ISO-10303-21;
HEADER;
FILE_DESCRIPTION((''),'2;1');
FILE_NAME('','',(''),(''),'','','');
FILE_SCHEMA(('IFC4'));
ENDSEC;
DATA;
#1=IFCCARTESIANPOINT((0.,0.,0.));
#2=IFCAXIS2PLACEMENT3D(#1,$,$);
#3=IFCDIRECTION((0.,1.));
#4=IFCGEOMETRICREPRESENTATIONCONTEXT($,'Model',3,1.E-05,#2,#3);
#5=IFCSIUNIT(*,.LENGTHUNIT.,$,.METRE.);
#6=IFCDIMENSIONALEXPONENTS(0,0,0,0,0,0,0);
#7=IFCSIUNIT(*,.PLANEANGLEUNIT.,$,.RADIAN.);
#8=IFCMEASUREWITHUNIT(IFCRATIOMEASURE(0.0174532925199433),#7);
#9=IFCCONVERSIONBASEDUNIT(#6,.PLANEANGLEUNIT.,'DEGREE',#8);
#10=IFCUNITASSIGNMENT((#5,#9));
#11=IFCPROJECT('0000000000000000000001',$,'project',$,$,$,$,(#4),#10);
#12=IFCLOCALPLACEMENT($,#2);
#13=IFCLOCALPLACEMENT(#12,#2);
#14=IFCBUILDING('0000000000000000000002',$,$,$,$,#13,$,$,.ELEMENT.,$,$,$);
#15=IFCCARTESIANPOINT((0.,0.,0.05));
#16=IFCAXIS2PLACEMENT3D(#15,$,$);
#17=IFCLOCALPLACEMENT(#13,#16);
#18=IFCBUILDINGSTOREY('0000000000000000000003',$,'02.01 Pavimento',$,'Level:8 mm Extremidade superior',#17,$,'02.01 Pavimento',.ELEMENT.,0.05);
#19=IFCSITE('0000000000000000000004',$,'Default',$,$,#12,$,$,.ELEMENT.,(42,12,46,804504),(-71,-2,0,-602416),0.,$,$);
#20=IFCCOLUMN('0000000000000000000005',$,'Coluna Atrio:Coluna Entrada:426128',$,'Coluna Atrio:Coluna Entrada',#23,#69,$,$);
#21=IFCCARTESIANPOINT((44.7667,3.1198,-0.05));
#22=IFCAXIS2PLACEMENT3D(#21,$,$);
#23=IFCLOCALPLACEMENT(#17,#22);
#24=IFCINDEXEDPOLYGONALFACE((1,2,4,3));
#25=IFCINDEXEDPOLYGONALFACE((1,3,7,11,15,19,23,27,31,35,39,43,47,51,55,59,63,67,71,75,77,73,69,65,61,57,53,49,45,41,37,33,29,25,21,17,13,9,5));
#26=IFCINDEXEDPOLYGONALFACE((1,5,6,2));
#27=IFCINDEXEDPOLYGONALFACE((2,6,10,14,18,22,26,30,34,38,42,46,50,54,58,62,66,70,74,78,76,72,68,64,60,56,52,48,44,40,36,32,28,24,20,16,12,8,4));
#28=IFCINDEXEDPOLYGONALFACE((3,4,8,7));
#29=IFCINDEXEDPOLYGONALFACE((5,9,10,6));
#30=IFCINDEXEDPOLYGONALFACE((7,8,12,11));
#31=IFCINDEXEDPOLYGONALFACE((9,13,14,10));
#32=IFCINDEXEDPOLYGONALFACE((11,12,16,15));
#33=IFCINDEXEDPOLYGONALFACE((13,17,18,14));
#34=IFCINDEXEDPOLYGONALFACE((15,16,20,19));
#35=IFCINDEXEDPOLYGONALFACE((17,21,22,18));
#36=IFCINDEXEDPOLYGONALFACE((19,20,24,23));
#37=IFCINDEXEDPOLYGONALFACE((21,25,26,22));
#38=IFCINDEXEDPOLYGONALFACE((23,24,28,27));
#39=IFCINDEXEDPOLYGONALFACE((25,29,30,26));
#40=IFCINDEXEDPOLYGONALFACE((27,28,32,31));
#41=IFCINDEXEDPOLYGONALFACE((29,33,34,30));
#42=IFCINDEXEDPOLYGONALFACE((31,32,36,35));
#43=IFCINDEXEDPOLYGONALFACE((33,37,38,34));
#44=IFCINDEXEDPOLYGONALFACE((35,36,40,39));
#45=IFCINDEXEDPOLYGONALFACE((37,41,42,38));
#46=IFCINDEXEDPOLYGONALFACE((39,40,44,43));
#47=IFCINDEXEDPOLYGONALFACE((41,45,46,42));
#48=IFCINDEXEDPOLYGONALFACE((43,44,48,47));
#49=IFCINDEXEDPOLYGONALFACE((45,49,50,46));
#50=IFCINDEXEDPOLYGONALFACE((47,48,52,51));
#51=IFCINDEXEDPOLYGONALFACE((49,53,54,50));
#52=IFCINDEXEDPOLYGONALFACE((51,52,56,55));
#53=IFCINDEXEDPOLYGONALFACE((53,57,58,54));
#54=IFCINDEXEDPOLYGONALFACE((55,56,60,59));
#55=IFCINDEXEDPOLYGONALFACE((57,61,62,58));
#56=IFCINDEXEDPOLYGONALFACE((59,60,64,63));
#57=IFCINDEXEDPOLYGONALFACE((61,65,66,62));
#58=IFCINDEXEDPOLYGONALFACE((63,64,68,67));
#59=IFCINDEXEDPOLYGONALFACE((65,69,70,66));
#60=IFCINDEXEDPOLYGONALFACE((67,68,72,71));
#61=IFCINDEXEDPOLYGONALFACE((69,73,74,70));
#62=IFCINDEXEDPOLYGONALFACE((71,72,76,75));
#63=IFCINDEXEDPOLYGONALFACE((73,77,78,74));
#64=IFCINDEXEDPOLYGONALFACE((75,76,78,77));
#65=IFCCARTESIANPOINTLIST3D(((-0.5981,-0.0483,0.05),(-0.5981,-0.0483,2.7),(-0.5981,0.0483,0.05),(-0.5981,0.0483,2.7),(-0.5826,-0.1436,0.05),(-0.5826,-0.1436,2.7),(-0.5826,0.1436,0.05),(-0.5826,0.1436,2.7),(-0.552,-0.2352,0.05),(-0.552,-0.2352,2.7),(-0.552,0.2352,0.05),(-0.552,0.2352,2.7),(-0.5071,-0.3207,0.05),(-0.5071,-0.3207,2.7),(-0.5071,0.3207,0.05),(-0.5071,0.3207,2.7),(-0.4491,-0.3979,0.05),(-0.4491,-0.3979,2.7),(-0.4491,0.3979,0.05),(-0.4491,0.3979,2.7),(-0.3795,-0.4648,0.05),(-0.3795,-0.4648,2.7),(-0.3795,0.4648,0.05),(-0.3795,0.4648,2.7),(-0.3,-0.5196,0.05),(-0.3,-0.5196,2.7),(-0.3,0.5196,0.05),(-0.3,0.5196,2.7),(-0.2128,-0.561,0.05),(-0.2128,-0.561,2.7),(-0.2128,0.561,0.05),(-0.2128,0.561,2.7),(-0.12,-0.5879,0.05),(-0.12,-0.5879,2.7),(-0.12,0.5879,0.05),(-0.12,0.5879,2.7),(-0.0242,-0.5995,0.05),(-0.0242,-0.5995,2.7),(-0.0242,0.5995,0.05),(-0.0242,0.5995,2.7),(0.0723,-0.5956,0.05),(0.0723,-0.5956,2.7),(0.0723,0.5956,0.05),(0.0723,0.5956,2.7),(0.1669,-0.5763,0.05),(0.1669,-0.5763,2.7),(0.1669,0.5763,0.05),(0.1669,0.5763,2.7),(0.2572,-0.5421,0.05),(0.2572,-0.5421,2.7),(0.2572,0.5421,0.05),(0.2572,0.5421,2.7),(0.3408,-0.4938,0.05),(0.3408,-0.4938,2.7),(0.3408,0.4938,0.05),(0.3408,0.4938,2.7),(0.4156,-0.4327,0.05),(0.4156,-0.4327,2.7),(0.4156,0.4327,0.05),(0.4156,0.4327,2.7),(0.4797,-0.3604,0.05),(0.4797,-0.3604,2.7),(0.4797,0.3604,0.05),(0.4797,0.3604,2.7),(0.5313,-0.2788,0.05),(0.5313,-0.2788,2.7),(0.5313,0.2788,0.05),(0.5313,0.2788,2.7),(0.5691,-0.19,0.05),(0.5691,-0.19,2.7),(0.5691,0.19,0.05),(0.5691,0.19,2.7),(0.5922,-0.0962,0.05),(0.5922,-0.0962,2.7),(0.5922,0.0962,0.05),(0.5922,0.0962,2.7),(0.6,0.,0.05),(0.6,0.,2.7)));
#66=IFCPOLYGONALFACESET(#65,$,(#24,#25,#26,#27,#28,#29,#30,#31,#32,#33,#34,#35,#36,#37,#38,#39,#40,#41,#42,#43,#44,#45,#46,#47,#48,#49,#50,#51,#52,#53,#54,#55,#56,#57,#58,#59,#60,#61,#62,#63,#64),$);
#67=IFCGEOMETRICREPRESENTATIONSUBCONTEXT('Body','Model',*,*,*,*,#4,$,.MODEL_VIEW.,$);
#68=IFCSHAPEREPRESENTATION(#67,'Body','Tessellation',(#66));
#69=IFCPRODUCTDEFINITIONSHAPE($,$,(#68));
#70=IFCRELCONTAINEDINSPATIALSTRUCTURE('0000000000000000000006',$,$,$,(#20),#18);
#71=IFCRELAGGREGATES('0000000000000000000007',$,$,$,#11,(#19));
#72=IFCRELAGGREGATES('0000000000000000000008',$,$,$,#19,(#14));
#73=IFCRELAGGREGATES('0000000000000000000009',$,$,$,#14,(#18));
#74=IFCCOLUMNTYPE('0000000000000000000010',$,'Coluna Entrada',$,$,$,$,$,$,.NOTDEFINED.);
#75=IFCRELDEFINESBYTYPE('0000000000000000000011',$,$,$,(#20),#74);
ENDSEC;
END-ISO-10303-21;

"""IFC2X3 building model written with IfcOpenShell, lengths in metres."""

from ifc_helpers import new_model, entity, si_unit, converted_unit, direction, frame, frame_2d, origin, place, context, subcontext, project, spatial, circle, extrude, source, transform, mapped, type_object, type_shapes, element, save


model = new_model("IFC2X3")

# Units and contexts
model_context = context("Model", 3, precision=1e-05, world=origin(), true_north=direction((0.0, 1.0)))
body_context = subcontext(model_context, "Body", "Model", "MODEL_VIEW")
ifc_project = project(units=[si_unit("LENGTHUNIT", "METRE"), converted_unit("PLANEANGLEUNIT", "DEGREE", entity("IfcRatioMeasure", 0.0174532925199433), si_unit("PLANEANGLEUNIT", "RADIAN"), dimensions=[0, 0, 0, 0, 0, 0, 0])], contexts=[model_context])

# Site, building, storey
site_placement = place(None, origin())
site = spatial("IfcSite", under=ifc_project, at=site_placement, Name="Default", CompositionType="ELEMENT", RefLatitude=(42, 12, 46, 804504), RefLongitude=(-71, -2, 0, -602416), RefElevation=0.0)
building_placement = place(site_placement, origin())
building = spatial("IfcBuilding", under=site, at=building_placement, CompositionType="ELEMENT")
storey_placement = place(building_placement, frame((0.0, 0.0, 0.05)))
storey = spatial("IfcBuildingStorey", under=building, at=storey_placement, Name="02.01 Pavimento", ObjectType="Level:8 mm Extremidade superior", LongName="02.01 Pavimento", CompositionType="ELEMENT", Elevation=0.05)

# Column
column_type_1 = type_object("IfcColumnType", Name="Coluna Entrada", PredefinedType="NOTDEFINED")
shared_shape_1 = source(origin(), body_context, "Body", "SweptSolid", [
    extrude(circle(Radius=0.6, at=frame_2d((0.0, 0.0), x_axis=(1.0, 0.0))), frame((0.0, 0.0, 0.05)), (0.0, 0.0, 1.0), 2.65),
])
type_shapes(column_type_1, [shared_shape_1])
column_1_placement = place(storey_placement, frame((44.7667, 3.1198, -0.05)))
element("IfcColumn", 1, at=column_1_placement, inside=storey, type_object=column_type_1, Name="Coluna Atrio:Coluna Entrada:426128", ObjectType="Coluna Atrio:Coluna Entrada", context=body_context, shape_type="MappedRepresentation", body=[
    mapped(shared_shape_1, transform((0.0, 0.0, 0.0), scale=1.0)),
])

save(model, "model.ifc")
